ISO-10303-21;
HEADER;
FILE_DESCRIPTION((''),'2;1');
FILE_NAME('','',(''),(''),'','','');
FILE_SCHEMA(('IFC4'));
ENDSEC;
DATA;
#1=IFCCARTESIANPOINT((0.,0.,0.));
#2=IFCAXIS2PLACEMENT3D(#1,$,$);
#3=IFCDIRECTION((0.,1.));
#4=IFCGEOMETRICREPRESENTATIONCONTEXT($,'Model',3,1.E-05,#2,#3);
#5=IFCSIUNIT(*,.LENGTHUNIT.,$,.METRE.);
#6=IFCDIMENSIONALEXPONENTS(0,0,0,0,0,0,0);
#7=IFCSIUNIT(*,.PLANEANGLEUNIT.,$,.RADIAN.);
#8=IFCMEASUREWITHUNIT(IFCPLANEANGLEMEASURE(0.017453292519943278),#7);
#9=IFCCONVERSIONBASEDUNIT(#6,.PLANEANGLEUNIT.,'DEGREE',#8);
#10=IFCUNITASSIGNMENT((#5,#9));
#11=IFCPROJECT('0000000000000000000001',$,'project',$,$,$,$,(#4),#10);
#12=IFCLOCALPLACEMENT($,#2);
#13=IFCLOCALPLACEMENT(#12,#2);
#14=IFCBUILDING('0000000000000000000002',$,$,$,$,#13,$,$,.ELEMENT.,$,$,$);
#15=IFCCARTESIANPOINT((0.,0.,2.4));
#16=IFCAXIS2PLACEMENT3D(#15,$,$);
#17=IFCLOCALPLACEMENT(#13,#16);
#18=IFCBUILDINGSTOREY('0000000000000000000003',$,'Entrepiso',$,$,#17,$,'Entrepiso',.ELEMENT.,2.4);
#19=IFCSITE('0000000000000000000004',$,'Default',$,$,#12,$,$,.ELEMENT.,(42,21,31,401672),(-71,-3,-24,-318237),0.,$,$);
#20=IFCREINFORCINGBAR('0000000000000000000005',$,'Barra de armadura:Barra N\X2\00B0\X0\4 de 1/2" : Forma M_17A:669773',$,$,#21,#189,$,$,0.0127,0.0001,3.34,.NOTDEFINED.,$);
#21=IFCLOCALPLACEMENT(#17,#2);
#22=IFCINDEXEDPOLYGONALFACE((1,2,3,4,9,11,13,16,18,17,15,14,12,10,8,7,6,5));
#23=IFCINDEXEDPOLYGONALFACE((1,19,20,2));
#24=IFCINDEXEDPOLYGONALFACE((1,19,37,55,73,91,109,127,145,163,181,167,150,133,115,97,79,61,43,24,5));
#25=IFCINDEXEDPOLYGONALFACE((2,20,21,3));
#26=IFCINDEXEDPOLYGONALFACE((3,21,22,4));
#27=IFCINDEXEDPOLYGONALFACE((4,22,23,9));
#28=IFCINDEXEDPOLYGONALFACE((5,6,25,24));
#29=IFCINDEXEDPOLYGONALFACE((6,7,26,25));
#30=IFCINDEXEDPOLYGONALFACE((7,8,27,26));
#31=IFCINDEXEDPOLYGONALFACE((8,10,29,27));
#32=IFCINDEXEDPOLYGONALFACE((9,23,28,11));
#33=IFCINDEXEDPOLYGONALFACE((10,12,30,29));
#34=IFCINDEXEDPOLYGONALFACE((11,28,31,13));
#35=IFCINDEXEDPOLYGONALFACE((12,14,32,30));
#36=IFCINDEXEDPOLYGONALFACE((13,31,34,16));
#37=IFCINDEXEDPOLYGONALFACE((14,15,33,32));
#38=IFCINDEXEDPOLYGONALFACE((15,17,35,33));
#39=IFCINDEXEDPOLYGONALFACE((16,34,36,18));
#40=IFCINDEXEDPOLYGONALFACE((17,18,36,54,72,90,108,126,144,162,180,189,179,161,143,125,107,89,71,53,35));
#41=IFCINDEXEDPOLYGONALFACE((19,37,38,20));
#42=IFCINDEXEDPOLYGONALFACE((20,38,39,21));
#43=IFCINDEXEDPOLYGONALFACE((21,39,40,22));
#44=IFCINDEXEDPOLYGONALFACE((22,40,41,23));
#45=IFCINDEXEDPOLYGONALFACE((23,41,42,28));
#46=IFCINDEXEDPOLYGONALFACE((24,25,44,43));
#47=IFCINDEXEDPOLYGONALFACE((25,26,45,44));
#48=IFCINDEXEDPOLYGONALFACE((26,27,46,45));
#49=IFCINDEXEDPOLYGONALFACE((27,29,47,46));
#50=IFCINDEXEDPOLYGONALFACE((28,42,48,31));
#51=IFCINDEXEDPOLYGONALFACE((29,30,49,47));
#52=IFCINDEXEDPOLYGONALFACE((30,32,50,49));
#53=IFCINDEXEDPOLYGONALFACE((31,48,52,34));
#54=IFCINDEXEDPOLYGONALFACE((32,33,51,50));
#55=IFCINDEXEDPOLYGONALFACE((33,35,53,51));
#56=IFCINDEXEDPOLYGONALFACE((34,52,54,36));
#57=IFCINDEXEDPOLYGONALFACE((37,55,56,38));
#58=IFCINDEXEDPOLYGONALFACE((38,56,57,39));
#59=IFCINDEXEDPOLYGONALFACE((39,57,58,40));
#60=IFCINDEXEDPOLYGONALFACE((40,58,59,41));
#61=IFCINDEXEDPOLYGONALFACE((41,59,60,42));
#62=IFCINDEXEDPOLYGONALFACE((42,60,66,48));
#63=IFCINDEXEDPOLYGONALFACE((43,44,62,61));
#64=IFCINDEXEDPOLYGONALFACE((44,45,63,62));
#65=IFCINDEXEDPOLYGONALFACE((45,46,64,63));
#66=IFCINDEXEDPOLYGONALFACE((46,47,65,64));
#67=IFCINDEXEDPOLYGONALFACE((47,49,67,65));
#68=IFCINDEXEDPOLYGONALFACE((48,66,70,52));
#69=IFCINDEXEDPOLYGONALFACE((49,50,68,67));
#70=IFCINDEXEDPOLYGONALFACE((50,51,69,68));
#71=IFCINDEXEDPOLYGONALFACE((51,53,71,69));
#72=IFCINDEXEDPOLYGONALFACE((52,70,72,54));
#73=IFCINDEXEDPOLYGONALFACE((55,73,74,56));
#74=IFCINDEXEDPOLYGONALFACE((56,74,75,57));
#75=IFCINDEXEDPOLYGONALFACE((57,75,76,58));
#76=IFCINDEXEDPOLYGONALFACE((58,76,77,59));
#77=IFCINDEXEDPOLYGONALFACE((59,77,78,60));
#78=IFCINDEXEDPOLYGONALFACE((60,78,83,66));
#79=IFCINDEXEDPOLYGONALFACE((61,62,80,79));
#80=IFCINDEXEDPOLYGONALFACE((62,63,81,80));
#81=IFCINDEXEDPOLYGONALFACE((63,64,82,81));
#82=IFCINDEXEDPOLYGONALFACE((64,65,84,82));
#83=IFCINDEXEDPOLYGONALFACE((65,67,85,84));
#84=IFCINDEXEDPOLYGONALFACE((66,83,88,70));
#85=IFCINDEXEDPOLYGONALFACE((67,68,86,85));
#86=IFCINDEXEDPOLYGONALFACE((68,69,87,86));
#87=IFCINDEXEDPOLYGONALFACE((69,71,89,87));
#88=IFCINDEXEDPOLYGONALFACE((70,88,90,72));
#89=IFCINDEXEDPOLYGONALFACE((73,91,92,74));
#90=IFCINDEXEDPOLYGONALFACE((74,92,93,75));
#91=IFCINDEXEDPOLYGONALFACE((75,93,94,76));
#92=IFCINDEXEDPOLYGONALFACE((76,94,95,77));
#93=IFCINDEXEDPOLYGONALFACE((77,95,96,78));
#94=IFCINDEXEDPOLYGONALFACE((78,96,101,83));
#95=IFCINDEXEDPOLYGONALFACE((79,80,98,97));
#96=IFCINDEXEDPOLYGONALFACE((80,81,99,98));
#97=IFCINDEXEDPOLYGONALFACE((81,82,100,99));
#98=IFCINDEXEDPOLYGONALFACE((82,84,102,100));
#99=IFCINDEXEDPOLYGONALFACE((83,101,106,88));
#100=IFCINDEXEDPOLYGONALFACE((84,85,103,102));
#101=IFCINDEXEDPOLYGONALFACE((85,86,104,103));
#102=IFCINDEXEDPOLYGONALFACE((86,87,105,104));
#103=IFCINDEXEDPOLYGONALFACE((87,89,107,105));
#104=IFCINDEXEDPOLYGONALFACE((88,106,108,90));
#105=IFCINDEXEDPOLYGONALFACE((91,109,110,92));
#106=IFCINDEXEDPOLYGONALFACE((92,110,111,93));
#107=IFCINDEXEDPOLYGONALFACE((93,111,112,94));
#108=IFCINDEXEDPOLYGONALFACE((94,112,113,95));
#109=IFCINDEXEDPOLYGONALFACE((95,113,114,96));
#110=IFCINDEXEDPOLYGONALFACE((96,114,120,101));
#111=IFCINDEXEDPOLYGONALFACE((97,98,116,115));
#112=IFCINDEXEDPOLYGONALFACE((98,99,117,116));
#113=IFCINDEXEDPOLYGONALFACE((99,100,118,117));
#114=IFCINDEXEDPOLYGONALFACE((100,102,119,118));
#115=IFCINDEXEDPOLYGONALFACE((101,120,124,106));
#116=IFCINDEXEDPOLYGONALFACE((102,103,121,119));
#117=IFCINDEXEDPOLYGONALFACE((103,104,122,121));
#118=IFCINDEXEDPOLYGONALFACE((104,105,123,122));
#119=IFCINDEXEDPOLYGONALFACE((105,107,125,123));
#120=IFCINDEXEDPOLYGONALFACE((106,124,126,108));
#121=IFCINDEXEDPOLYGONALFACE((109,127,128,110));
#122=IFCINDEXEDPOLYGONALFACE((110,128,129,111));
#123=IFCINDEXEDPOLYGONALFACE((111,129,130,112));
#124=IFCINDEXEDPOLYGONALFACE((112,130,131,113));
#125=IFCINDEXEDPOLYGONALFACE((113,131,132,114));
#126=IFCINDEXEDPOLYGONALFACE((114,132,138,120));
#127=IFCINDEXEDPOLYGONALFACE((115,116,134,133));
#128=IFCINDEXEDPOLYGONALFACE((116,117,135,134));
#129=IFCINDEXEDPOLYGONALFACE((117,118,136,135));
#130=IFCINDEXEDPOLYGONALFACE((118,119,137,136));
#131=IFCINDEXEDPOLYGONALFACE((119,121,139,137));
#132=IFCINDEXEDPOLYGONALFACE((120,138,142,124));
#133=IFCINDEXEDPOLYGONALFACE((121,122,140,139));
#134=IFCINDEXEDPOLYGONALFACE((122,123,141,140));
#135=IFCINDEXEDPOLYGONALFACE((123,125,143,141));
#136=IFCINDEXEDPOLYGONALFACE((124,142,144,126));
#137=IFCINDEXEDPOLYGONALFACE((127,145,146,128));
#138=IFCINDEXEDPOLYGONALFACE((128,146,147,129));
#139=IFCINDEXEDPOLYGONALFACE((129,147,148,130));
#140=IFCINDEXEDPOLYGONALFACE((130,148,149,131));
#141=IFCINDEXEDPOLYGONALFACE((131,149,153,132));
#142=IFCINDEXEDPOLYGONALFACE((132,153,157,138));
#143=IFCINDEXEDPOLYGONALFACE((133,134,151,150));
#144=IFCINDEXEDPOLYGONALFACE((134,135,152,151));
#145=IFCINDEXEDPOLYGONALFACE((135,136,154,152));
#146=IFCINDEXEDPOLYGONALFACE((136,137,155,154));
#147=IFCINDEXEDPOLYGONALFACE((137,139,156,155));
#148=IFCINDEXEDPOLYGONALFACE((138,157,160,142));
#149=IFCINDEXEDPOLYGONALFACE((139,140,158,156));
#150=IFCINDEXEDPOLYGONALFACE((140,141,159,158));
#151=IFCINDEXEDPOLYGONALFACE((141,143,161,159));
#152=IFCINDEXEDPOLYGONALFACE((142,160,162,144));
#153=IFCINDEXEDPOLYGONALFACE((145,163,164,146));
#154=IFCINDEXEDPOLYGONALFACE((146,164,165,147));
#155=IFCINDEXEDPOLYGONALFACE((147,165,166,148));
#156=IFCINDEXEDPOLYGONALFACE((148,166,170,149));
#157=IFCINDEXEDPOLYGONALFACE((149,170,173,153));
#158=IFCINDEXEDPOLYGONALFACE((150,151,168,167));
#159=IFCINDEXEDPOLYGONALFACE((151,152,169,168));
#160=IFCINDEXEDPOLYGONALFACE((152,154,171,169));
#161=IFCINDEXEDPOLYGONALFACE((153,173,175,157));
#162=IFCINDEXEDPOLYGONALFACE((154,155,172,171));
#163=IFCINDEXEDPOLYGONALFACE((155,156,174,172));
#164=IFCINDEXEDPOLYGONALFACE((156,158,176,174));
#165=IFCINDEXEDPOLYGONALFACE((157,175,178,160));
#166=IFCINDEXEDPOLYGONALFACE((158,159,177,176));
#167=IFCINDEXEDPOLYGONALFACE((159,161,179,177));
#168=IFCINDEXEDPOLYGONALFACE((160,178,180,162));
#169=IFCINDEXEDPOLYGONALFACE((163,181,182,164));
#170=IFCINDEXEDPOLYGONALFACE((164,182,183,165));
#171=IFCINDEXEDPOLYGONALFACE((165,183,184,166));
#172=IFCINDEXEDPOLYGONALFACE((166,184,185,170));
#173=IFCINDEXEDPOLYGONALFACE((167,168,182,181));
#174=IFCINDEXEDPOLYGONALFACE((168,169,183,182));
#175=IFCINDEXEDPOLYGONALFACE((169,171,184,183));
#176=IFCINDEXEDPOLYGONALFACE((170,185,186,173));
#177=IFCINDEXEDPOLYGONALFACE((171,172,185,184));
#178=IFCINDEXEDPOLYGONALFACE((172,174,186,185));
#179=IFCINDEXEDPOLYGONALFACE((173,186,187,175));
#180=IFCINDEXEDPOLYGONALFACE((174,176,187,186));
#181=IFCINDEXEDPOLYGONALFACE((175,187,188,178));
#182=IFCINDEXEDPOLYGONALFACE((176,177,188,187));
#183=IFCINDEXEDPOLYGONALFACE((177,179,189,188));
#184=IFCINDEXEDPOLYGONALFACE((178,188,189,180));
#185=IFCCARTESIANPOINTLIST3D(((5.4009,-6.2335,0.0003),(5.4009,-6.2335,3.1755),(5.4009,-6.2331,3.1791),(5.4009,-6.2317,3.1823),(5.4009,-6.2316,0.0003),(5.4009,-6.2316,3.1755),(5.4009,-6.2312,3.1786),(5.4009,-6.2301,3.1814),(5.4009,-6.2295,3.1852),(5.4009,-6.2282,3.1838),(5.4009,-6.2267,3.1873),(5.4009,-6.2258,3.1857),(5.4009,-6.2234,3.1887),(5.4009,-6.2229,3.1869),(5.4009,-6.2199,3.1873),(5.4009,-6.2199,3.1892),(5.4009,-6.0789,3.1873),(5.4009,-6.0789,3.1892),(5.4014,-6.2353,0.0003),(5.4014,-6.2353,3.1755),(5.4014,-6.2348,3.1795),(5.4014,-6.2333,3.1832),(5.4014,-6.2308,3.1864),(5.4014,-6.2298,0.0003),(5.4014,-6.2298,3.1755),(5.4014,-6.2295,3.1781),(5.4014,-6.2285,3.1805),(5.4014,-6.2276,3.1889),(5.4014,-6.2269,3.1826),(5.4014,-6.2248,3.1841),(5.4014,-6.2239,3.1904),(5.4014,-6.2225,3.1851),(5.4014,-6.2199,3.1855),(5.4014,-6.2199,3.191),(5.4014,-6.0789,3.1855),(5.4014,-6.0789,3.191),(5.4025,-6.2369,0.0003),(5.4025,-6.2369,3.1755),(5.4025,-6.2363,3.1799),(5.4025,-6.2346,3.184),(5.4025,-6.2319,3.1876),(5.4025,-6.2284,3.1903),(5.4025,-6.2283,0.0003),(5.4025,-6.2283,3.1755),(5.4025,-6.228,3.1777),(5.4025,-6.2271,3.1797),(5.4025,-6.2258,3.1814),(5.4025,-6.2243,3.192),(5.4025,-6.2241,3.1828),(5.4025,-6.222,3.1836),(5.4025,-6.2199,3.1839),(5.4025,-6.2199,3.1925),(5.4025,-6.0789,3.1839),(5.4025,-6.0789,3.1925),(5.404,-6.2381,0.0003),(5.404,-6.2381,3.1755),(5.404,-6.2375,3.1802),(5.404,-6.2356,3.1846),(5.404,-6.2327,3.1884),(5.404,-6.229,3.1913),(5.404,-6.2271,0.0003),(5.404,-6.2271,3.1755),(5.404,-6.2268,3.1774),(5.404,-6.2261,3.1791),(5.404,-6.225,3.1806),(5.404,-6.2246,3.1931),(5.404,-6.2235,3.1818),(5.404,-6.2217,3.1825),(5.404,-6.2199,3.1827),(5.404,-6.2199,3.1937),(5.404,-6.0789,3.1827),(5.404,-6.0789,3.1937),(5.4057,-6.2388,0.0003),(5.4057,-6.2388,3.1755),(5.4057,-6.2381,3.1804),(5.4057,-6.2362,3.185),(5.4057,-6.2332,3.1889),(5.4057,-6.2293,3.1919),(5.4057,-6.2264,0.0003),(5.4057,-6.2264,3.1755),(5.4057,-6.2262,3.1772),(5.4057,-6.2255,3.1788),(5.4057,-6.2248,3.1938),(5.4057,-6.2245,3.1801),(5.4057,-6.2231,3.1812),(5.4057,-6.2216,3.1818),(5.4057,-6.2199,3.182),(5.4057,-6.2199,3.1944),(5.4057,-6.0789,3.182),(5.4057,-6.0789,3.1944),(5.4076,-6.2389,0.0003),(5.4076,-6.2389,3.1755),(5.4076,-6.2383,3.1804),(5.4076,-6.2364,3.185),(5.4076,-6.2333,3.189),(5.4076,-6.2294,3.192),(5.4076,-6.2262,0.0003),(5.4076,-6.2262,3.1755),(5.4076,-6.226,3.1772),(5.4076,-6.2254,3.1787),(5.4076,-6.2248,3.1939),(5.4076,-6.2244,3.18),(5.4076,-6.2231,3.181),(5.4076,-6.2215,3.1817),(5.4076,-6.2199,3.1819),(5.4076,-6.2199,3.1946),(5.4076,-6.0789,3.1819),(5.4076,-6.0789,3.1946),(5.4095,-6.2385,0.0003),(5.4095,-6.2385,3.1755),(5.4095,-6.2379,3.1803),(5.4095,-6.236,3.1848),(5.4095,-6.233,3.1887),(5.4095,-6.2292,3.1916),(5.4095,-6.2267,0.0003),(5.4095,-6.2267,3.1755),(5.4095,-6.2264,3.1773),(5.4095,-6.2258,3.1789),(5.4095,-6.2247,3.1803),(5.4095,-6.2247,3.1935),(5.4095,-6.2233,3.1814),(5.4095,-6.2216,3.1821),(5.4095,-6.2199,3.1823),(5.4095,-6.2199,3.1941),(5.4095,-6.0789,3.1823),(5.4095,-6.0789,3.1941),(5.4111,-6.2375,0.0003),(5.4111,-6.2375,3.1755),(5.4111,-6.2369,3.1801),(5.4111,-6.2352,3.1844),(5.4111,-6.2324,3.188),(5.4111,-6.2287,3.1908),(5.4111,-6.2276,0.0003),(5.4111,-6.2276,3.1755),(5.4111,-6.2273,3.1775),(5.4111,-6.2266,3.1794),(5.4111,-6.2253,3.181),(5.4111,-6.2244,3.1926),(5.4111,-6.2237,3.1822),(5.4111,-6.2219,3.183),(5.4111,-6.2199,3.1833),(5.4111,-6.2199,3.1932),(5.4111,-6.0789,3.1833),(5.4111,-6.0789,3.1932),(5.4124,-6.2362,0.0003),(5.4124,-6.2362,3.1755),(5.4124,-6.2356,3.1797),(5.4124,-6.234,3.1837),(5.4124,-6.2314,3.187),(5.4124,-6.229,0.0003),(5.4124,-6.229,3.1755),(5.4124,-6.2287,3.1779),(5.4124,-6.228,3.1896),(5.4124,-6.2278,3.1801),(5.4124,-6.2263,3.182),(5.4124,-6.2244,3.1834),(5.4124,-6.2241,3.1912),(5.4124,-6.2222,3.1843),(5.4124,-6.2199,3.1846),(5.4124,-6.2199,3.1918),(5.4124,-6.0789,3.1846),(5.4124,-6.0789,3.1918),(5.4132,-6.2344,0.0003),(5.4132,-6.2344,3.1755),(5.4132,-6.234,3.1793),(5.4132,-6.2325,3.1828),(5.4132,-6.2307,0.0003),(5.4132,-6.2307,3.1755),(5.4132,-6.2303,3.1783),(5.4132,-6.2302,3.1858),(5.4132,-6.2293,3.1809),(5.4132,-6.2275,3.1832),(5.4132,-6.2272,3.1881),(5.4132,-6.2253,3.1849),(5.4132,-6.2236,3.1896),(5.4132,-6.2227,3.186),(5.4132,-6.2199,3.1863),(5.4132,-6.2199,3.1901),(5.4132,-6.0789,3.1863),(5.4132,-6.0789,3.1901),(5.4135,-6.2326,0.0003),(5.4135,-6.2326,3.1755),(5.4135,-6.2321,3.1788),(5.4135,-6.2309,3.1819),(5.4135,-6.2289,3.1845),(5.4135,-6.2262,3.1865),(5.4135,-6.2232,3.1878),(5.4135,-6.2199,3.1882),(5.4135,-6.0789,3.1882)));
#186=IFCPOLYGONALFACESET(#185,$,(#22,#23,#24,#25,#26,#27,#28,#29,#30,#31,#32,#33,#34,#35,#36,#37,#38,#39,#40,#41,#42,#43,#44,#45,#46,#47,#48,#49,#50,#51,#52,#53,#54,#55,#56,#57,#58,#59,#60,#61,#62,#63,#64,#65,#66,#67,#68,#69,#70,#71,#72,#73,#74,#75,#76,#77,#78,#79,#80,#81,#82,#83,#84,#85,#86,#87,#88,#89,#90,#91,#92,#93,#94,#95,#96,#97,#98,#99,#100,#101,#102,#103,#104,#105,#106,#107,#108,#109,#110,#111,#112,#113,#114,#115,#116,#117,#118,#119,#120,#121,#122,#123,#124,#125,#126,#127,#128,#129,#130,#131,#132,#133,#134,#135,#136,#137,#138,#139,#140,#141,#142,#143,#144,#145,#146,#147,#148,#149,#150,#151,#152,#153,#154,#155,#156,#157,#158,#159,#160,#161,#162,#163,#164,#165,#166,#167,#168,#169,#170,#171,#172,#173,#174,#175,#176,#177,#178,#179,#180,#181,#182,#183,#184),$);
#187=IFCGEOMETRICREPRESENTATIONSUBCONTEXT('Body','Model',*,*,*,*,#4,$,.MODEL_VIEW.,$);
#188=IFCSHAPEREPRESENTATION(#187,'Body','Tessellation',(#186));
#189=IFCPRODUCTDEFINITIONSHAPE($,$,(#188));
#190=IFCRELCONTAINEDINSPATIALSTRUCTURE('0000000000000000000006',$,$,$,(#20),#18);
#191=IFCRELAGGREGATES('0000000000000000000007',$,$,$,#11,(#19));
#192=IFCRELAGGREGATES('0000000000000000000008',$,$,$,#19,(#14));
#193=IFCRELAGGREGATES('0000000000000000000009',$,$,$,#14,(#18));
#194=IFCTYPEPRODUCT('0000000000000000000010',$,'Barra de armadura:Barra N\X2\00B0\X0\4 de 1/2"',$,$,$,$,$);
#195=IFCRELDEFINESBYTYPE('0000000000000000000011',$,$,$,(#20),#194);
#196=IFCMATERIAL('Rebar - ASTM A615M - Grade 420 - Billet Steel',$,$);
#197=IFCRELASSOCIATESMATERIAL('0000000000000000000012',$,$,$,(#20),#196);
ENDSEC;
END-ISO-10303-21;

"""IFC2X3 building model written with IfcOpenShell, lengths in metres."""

from ifc_helpers import new_model, entity, si_unit, converted_unit, direction, frame, origin, place, context, subcontext, project, spatial, material, type_object, element, save


model = new_model("IFC2X3")

# Units and contexts
model_context = context("Model", 3, precision=1e-05, world=origin(), true_north=direction((0.0, 1.0)))
body_context = subcontext(model_context, "Body", "Model", "MODEL_VIEW")
ifc_project = project(units=[si_unit("LENGTHUNIT", "METRE"), converted_unit("PLANEANGLEUNIT", "DEGREE", entity("IfcPlaneAngleMeasure", 0.017453292519943278), si_unit("PLANEANGLEUNIT", "RADIAN"), dimensions=[0, 0, 0, 0, 0, 0, 0])], contexts=[model_context])

# Site, building, storey
site_placement = place(None, origin())
site = spatial("IfcSite", under=ifc_project, at=site_placement, Name="Default", CompositionType="ELEMENT", RefLatitude=(42, 21, 31, 401672), RefLongitude=(-71, -3, -24, -318237), RefElevation=0.0)
building_placement = place(site_placement, origin())
building = spatial("IfcBuilding", under=site, at=building_placement, CompositionType="ELEMENT")
storey_placement = place(building_placement, frame((0.0, 0.0, 2.4)))
storey = spatial("IfcBuildingStorey", under=building, at=storey_placement, Name="Entrepiso", LongName="Entrepiso", CompositionType="ELEMENT", Elevation=2.4)

# Reinforcing bar
ifc_material = material(Name="Rebar - ASTM A615M - Grade 420 - Billet Steel")
type_product_1 = type_object("IfcTypeProduct", Name="Barra de armadura:Barra N°4 de 1/2\"")
reinforcing_bar_1_placement = place(storey_placement, origin())
element("IfcReinforcingBar", 1, at=reinforcing_bar_1_placement, inside=storey, type_object=type_product_1, material=ifc_material, Name="Barra de armadura:Barra N°4 de 1/2\" : Forma M_17A:669773", BarLength=3.34, BarRole="NOTDEFINED", CrossSectionArea=0.0001, NominalDiameter=0.0127, context=body_context, shape_type="AdvancedSweptSolid", body=[
    entity("IfcSweptDiskSolid", entity("IfcCompositeCurve", [entity("IfcCompositeCurveSegment", "CONTINUOUS", True, entity("IfcPolyline", [entity("IfcCartesianPoint", [5.4071, -6.2326, 0.0003]), entity("IfcCartesianPoint", [5.4071, -6.2326, 3.1755])])), entity("IfcCompositeCurveSegment", "CONTINUOUS", True, entity("IfcTrimmedCurve", entity("IfcCircle", entity("IfcAxis2Placement3D", entity("IfcCartesianPoint", [5.4071, -6.2199, 3.1755]), entity("IfcDirection", [-1.0, 0.0, 0.0]), entity("IfcDirection", [0.0, 0.0, 1.0])), 0.0127), [entity("IfcParameterValue", 270.0)], [entity("IfcParameterValue", 360.0)], True, "PARAMETER")), entity("IfcCompositeCurveSegment", "CONTINUOUS", True, entity("IfcPolyline", [entity("IfcCartesianPoint", [5.4071, -6.2199, 3.1882]), entity("IfcCartesianPoint", [5.4071, -6.0789, 3.1882])]))], False), 0.0063, None, 0.0, 92.0),
])

save(model, "model.ifc")
